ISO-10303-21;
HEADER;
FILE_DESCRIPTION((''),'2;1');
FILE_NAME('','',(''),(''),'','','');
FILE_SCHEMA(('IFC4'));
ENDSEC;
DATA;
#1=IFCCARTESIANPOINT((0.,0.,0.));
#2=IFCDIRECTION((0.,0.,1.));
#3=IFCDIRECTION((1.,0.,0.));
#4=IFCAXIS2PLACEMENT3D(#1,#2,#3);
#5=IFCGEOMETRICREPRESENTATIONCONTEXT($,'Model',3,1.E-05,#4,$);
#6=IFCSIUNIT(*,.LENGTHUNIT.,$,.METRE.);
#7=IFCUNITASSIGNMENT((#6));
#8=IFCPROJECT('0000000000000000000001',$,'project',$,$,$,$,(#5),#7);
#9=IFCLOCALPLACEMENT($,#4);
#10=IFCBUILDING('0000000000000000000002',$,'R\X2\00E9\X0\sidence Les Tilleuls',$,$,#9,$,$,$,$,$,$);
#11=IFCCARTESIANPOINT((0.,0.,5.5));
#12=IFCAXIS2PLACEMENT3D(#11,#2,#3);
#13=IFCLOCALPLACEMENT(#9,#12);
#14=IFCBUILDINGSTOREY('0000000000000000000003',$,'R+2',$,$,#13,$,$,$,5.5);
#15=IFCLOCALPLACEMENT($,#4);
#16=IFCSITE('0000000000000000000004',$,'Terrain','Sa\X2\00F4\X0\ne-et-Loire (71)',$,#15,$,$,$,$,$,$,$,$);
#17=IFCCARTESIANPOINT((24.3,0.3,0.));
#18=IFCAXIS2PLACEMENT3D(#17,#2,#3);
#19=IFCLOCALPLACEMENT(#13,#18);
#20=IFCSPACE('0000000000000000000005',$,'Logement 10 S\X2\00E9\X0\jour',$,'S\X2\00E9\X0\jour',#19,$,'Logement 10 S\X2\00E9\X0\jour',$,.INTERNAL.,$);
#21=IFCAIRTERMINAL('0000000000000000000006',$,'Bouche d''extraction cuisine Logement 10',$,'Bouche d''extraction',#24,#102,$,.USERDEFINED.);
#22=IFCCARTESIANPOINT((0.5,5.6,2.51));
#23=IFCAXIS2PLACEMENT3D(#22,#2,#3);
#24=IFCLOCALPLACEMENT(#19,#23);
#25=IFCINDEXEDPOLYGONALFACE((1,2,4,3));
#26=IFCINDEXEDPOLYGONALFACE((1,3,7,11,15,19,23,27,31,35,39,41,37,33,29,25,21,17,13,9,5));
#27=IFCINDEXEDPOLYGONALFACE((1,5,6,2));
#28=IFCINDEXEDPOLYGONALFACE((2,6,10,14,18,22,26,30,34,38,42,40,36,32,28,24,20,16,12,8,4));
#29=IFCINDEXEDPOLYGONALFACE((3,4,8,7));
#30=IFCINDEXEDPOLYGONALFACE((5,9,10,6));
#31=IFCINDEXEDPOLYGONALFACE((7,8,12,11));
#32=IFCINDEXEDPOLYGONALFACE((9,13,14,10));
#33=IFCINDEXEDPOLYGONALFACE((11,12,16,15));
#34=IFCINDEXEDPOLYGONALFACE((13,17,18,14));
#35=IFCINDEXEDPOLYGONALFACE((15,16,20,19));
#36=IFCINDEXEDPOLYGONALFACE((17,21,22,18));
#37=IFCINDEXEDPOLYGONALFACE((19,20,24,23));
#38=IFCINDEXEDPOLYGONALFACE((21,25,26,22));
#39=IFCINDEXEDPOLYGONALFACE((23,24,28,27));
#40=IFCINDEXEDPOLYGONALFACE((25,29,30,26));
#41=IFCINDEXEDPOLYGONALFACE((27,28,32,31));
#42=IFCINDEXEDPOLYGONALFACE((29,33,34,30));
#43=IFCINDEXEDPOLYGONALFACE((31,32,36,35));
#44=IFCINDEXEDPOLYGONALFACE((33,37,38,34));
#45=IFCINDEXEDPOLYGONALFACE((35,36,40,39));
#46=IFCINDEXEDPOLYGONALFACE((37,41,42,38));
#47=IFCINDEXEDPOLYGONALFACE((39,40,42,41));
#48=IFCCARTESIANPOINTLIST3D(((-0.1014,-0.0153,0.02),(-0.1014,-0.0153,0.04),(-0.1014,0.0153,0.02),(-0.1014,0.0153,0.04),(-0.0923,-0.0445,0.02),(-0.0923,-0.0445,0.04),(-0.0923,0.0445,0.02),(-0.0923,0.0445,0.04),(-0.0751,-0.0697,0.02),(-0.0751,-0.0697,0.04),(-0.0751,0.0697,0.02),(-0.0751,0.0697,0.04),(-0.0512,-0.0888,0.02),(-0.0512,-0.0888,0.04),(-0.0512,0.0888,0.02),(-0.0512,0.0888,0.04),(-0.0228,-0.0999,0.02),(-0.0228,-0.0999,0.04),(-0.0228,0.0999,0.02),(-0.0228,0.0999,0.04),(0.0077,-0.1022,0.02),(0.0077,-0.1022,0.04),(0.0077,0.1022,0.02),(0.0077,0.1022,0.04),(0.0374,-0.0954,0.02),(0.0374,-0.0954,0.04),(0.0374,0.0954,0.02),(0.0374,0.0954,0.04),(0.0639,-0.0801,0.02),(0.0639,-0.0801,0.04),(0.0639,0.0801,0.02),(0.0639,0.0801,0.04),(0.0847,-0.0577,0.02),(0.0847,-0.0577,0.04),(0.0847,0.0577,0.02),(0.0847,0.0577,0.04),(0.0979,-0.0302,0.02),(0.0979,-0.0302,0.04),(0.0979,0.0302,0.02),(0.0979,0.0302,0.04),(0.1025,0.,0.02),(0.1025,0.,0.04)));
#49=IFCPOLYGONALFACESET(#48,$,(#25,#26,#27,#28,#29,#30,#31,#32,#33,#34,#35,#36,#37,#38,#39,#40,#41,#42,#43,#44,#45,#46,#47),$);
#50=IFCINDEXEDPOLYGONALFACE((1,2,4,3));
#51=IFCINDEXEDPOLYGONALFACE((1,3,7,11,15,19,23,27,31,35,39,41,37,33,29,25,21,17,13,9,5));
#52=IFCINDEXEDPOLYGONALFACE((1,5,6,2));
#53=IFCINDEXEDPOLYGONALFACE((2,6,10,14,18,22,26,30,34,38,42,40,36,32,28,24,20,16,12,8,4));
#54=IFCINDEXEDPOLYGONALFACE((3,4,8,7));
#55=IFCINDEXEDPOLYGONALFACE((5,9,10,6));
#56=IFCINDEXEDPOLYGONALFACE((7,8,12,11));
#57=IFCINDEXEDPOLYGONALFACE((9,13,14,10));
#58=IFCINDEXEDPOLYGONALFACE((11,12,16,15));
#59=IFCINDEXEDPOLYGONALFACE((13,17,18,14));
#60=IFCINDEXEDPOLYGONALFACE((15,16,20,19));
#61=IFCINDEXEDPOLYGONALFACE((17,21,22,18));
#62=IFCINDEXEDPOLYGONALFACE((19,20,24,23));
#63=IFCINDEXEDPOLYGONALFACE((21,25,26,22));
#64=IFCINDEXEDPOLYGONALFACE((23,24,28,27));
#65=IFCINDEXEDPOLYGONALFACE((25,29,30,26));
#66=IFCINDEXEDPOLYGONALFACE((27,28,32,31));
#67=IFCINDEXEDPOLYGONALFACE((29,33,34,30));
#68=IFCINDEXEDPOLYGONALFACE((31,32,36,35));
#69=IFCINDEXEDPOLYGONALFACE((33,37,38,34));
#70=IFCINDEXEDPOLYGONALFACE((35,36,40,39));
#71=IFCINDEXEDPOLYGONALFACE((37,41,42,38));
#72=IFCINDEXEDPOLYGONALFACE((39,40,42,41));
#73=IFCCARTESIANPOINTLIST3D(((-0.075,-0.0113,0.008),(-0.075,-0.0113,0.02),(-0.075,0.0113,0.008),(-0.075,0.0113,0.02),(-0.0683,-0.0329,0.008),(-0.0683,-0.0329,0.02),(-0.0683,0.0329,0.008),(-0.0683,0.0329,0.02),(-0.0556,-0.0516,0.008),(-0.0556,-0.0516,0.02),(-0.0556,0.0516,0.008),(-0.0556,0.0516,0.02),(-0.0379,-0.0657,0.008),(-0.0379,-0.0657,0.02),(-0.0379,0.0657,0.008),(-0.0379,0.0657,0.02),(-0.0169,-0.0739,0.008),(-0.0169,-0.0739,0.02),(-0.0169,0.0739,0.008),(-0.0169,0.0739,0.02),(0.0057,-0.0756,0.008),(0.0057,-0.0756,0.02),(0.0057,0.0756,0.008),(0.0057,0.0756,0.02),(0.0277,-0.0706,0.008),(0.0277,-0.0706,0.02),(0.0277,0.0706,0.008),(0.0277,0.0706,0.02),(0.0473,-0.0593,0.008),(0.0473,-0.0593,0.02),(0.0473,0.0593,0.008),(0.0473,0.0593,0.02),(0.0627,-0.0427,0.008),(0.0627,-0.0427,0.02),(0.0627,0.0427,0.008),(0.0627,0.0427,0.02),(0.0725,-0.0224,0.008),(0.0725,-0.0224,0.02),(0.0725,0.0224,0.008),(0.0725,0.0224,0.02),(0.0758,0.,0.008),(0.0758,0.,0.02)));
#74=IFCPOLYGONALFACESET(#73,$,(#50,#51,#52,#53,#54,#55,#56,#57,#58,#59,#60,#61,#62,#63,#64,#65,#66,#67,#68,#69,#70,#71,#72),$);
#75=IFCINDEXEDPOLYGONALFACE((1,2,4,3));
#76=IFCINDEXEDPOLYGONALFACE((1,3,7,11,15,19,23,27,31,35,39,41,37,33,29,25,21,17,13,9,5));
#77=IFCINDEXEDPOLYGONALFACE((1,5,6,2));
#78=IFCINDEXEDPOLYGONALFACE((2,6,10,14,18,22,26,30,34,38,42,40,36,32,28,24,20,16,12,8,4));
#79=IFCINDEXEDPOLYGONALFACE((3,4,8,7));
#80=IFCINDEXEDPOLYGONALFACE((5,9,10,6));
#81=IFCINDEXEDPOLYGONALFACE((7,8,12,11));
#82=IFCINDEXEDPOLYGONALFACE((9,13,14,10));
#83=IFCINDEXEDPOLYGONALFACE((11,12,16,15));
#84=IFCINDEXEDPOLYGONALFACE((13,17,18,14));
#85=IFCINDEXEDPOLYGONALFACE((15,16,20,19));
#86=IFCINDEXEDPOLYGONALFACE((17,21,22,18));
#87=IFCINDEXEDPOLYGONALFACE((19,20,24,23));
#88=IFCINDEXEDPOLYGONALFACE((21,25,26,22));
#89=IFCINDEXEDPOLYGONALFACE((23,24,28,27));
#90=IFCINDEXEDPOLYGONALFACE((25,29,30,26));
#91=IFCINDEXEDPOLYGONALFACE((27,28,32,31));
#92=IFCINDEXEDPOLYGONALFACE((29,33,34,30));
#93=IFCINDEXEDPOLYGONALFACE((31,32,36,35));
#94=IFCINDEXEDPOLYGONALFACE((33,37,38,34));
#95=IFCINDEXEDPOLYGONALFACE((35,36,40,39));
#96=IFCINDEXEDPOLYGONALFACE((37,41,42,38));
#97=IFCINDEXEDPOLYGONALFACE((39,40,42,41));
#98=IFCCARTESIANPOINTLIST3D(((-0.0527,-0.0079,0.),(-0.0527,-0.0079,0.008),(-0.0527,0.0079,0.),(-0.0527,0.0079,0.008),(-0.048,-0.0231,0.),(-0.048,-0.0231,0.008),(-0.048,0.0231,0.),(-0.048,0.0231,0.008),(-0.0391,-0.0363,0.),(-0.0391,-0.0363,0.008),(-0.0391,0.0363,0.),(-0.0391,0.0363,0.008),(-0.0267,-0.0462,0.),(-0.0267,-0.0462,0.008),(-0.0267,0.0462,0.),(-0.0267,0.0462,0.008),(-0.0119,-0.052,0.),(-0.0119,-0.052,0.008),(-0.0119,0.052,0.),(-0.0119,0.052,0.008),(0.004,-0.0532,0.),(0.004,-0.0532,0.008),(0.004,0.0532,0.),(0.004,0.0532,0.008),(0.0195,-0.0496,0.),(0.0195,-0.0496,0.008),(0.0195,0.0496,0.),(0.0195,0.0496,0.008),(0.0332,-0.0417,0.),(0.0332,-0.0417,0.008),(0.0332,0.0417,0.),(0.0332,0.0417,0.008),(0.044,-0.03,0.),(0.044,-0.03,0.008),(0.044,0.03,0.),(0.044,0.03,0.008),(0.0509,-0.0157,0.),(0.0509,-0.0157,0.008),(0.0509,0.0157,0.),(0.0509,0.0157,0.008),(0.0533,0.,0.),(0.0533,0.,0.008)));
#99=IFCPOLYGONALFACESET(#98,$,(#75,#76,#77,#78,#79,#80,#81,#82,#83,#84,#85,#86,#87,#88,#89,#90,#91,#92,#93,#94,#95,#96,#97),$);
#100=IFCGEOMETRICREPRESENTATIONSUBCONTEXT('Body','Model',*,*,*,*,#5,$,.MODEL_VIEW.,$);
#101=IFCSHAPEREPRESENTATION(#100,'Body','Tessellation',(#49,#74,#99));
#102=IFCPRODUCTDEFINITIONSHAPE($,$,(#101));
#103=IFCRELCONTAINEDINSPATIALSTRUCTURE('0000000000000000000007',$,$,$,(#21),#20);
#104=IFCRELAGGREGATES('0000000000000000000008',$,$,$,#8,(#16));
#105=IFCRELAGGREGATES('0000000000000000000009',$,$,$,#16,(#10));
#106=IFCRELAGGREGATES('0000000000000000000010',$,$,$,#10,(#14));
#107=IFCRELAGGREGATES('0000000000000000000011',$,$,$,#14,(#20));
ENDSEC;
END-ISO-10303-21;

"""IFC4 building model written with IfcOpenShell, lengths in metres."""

from ifc_helpers import new_model, si_unit, frame, origin_with_axes, place, context, subcontext, project, spatial, circle, extrude, element, save


model = new_model("IFC4")

# Units and contexts
model_context = context("Model", 3, precision=1e-05, world=origin_with_axes())
body_context = subcontext(model_context, "Body", "Model", "MODEL_VIEW")
ifc_project = project(units=[si_unit("LENGTHUNIT", "METRE")], contexts=[model_context])

# Site, building, storey
site_placement = place(None, origin_with_axes())
site = spatial("IfcSite", under=ifc_project, at=site_placement, Name="Terrain", Description="Saône-et-Loire (71)")
building_placement = place(None, origin_with_axes())
building = spatial("IfcBuilding", under=site, at=building_placement, Name="Résidence Les Tilleuls")
storey_placement = place(building_placement, frame((0.0, 0.0, 5.5), z_axis=(0.0, 0.0, 1.0), x_axis=(1.0, 0.0, 0.0)))
storey = spatial("IfcBuildingStorey", under=building, at=storey_placement, Name="R+2", Elevation=5.5)

# Shared definitions
space_placement = place(storey_placement, frame((24.3, 0.3, 0.0), z_axis=(0.0, 0.0, 1.0), x_axis=(1.0, 0.0, 0.0)))
space = spatial("IfcSpace", under=storey, at=space_placement, Name="Logement 10 Séjour", ObjectType="Séjour", LongName="Logement 10 Séjour", PredefinedType="INTERNAL")

# Air terminal
air_terminal_1_placement = place(space_placement, frame((0.5, 5.6, 2.51), z_axis=(0.0, 0.0, 1.0), x_axis=(1.0, 0.0, 0.0)))
element("IfcAirTerminal", 1, at=air_terminal_1_placement, inside=space, Name="Bouche d'extraction cuisine Logement 10", ObjectType="Bouche d'extraction", PredefinedType="USERDEFINED", context=body_context, shape_type="SweptSolid", body=[
    extrude(circle(Radius=0.1025), frame((0.0, 0.0, 0.02), z_axis=(0.0, 0.0, 1.0), x_axis=(1.0, 0.0, 0.0)), (0.0, 0.0, 1.0), 0.02),
    extrude(circle(Radius=0.0759), frame((0.0, 0.0, 0.008), z_axis=(0.0, 0.0, 1.0), x_axis=(1.0, 0.0, 0.0)), (0.0, 0.0, 1.0), 0.012),
    extrude(circle(Radius=0.0533), origin_with_axes(), (0.0, 0.0, 1.0), 0.008),
])

save(model, "model.ifc")
